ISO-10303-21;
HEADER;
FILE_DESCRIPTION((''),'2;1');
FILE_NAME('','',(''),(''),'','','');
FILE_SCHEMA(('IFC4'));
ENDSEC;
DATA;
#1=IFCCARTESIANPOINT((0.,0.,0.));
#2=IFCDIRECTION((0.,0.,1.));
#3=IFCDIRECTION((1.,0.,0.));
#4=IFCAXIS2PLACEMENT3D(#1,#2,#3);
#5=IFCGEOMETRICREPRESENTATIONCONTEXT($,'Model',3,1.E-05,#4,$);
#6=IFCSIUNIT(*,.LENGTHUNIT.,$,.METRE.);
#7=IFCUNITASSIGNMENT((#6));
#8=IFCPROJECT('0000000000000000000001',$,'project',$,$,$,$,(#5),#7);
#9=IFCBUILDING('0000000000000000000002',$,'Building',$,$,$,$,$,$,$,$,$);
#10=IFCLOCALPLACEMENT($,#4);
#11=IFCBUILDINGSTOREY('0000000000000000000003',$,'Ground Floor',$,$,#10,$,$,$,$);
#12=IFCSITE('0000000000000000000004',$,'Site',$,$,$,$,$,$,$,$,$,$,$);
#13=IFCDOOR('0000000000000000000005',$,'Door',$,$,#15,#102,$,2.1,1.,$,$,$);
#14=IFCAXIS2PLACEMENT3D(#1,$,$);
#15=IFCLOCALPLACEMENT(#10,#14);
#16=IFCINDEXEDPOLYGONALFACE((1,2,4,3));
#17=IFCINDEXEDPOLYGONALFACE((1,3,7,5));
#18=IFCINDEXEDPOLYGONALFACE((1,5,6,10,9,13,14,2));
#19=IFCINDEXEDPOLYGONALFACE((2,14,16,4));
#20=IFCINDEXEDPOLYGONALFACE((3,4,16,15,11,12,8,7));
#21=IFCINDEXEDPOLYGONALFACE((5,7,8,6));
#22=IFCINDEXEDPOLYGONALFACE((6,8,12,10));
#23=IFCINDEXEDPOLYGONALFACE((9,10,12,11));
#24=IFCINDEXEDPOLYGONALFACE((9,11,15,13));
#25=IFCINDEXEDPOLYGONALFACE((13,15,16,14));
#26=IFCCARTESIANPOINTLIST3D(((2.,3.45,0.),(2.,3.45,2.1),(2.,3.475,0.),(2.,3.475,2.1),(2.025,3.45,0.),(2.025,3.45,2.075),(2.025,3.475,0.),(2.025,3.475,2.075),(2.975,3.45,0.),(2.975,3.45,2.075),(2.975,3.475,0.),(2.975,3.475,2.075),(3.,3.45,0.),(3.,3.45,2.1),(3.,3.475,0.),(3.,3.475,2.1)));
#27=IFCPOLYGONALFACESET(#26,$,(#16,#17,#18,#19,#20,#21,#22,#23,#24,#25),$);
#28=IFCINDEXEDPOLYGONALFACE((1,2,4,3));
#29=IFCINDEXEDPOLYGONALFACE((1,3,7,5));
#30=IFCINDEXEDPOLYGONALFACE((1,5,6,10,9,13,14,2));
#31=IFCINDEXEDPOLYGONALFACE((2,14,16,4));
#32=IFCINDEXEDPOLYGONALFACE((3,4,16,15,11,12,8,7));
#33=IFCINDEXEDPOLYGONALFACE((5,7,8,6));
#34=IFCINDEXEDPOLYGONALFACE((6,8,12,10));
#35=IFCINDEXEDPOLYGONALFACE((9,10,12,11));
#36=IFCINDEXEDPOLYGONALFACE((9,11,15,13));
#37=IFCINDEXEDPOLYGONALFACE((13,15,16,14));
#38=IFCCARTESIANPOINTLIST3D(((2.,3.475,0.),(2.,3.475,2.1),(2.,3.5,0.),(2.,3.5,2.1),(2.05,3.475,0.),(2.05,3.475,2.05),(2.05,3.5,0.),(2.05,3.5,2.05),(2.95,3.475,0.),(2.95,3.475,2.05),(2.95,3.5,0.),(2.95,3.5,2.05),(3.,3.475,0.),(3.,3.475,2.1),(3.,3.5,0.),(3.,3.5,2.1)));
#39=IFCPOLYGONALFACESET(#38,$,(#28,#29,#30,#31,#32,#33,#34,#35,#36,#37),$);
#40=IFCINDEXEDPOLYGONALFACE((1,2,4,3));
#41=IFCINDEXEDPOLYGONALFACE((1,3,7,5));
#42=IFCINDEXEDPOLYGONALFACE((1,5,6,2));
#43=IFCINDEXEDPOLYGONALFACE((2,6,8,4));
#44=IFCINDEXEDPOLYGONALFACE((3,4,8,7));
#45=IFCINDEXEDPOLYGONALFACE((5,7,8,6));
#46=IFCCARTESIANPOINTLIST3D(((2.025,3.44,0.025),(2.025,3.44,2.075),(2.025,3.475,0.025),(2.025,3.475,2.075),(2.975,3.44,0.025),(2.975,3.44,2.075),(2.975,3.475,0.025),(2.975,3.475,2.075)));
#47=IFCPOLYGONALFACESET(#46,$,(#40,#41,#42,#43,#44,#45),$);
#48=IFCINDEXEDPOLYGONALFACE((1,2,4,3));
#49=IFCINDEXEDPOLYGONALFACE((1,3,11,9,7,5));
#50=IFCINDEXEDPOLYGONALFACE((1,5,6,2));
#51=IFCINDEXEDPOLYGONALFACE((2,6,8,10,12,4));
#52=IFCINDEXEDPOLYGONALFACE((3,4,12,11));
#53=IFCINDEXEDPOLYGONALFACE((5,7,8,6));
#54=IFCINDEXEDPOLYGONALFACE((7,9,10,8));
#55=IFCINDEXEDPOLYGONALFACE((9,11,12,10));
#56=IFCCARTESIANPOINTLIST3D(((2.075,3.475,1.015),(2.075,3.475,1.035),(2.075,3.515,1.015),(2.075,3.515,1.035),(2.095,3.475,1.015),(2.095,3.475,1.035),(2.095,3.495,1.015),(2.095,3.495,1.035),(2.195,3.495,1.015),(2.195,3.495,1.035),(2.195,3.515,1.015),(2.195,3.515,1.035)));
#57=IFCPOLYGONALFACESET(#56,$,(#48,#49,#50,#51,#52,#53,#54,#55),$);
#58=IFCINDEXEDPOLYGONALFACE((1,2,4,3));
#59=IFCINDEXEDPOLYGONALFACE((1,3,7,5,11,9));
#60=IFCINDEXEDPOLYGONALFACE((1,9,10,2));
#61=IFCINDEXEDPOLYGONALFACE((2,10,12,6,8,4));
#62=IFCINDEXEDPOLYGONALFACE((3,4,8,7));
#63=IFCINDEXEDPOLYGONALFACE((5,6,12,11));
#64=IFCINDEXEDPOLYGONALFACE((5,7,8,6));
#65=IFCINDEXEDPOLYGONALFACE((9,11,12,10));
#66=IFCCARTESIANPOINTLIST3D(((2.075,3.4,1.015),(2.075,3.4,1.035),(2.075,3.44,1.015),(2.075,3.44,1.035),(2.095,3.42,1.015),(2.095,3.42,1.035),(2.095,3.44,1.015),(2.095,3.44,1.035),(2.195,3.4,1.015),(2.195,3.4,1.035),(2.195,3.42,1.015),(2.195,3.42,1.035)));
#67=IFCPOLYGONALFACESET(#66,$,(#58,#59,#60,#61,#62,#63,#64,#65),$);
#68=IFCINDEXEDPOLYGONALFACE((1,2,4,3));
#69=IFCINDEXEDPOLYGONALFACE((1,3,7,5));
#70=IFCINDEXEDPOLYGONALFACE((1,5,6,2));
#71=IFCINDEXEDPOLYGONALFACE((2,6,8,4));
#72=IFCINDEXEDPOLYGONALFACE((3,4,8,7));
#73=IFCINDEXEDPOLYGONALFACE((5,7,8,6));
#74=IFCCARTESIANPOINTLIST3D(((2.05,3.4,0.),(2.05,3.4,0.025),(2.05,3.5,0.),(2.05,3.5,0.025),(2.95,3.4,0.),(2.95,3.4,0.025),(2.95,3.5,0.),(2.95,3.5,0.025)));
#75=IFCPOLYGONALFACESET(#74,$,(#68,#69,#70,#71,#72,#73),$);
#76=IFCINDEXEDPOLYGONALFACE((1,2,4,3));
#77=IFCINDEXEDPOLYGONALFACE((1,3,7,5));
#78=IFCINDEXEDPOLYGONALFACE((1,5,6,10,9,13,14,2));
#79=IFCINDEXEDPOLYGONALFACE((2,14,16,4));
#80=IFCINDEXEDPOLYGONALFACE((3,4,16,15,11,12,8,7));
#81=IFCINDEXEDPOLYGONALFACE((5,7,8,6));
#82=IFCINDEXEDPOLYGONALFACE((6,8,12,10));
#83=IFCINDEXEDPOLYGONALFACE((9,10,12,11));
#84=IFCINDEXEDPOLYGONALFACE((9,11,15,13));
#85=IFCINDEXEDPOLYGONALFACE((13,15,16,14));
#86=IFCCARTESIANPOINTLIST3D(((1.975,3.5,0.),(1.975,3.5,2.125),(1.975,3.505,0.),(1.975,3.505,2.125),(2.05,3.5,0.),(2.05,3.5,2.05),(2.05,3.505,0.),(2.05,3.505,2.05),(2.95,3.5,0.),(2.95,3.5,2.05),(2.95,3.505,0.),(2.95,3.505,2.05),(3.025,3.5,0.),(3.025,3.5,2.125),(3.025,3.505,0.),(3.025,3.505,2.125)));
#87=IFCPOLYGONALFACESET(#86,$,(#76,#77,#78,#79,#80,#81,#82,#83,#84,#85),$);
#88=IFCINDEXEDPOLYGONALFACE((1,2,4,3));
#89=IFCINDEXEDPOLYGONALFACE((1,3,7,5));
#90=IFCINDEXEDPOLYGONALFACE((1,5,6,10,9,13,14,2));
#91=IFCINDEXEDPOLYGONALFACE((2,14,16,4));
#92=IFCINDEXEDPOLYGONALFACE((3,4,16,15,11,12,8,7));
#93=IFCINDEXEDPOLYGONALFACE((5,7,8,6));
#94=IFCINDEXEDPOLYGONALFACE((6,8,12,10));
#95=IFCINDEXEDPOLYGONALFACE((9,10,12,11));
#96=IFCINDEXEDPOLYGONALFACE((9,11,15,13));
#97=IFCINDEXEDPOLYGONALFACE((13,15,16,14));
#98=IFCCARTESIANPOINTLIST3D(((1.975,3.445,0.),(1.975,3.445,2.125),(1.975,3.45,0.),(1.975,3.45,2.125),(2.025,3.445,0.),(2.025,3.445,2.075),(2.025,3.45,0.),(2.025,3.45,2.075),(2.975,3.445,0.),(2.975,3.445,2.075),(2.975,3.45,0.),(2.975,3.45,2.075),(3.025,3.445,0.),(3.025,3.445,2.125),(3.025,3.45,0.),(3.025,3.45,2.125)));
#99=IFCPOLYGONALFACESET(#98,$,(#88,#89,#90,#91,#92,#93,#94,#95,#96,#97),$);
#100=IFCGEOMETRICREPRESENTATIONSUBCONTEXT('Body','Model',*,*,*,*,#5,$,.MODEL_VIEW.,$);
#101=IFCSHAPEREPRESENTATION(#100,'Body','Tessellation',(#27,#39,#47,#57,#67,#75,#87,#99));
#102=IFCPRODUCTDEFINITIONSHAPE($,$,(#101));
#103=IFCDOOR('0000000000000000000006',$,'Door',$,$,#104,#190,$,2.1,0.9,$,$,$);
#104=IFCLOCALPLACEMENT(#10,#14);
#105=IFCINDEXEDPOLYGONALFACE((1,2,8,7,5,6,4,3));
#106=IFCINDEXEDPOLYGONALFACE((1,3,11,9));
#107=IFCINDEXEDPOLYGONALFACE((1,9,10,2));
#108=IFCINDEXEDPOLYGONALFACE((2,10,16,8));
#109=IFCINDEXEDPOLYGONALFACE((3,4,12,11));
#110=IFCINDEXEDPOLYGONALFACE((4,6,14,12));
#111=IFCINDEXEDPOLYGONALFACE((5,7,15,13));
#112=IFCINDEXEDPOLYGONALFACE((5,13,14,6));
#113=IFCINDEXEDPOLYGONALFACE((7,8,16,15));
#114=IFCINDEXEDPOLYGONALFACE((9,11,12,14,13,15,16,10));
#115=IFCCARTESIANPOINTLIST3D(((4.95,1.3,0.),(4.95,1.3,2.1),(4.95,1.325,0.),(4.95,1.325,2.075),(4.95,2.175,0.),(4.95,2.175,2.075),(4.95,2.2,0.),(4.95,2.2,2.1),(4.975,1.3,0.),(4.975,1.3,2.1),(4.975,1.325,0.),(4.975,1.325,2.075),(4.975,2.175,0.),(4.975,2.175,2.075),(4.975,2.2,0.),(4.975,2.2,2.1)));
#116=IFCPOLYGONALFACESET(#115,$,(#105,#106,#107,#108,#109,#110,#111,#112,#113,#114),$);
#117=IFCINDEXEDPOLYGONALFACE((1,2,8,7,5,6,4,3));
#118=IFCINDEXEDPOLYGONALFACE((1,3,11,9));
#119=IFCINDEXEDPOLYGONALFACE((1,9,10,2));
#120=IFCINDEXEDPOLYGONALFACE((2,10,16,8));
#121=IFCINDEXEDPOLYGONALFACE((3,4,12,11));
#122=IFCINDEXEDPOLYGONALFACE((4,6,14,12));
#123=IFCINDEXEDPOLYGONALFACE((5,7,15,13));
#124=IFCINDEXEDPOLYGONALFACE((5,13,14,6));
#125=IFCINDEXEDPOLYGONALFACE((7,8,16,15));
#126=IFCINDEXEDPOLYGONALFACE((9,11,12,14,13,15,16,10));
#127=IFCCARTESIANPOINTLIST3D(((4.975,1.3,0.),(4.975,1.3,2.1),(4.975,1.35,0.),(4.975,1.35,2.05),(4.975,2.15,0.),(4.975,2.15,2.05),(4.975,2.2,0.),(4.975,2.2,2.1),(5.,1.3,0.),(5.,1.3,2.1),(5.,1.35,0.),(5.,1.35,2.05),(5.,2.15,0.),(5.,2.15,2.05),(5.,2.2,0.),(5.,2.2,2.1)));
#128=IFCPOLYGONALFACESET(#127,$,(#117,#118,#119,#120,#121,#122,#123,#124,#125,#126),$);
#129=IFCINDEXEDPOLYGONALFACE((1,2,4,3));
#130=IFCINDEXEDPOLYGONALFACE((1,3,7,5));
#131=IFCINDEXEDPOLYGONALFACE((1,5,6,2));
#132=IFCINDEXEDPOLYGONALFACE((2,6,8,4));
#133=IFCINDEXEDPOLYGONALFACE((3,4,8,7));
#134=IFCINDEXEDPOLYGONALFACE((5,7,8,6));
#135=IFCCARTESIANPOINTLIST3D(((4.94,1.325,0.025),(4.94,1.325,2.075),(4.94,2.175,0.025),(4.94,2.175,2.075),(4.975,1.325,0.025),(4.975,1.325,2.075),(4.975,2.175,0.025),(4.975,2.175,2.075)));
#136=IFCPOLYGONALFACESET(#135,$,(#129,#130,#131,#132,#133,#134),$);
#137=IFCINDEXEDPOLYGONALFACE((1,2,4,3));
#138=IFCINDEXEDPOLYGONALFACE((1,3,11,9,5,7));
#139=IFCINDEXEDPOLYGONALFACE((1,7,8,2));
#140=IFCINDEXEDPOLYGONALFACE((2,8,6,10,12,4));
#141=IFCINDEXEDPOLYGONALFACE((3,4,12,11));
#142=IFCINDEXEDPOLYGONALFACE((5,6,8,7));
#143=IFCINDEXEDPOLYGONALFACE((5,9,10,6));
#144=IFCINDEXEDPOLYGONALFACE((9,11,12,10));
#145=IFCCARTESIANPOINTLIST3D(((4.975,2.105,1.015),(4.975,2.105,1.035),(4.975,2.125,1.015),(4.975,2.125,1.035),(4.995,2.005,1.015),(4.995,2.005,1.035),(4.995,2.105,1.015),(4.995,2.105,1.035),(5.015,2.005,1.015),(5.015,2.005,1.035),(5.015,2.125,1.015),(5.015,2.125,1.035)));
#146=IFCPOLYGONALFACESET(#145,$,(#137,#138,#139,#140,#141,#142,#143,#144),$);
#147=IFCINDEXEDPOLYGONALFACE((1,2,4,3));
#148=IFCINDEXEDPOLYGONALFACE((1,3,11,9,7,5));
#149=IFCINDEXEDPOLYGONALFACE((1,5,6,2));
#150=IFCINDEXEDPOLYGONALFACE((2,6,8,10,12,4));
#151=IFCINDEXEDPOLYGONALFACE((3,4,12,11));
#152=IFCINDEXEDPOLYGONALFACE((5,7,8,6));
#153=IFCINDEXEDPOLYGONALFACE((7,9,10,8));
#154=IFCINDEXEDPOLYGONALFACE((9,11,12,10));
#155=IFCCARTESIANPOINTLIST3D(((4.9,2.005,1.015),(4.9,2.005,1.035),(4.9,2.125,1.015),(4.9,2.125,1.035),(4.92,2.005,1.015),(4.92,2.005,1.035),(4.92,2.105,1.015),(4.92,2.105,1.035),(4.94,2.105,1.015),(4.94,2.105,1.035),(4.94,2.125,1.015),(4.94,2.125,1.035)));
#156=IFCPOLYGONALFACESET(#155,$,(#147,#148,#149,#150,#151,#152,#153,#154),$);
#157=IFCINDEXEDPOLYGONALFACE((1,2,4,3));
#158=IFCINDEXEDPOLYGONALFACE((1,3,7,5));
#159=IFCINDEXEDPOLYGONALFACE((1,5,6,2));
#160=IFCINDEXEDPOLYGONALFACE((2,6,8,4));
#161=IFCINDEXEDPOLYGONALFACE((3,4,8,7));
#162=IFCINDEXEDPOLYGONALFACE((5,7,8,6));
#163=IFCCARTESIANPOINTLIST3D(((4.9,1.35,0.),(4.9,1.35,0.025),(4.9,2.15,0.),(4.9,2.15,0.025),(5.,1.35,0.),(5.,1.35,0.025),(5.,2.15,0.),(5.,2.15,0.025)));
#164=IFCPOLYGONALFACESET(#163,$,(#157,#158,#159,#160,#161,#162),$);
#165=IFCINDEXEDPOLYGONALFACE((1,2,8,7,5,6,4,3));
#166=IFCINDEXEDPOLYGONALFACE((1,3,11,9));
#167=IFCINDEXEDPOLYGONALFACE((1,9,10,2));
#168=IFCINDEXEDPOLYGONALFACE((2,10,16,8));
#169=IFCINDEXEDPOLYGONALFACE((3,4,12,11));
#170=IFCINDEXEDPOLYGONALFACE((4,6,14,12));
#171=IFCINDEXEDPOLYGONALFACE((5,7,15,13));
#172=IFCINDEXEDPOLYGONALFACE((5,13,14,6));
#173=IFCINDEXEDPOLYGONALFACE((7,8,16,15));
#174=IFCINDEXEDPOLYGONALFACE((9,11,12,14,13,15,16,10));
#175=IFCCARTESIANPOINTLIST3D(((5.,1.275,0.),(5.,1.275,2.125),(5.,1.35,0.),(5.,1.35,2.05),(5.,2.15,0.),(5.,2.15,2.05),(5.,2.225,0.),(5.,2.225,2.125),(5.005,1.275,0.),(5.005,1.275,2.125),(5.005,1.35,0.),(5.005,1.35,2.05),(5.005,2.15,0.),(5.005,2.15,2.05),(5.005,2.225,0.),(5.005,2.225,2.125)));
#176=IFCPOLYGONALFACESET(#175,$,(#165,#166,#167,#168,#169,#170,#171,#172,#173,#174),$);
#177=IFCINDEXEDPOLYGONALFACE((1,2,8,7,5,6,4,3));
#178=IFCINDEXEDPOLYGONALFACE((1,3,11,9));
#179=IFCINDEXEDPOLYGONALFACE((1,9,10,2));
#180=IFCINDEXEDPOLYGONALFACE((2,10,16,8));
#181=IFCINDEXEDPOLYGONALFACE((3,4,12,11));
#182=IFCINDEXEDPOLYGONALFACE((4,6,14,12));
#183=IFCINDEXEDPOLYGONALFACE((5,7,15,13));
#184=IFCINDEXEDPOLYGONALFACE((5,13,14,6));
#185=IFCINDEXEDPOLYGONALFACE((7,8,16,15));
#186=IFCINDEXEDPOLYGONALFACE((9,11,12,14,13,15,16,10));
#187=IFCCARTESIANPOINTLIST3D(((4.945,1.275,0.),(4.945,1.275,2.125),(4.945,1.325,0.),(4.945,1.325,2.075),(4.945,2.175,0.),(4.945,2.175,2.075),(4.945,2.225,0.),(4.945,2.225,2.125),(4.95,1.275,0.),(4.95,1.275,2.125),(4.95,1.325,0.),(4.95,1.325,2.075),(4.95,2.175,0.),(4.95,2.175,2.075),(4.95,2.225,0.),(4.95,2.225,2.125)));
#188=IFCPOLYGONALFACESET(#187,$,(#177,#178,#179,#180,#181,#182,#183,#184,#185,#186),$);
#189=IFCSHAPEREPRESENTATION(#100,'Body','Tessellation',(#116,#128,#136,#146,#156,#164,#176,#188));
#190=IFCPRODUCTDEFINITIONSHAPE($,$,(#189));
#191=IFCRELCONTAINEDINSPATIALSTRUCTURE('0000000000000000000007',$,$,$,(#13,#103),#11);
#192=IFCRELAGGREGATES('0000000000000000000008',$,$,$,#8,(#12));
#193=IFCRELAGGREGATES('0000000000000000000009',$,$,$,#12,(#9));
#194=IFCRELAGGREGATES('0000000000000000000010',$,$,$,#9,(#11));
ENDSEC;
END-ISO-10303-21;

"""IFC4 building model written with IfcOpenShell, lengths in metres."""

from ifc_helpers import new_model, si_unit, frame, origin_with_axes, place, context, subcontext, project, spatial, line, indexed_curve, outline, extrude, element, save


model = new_model("IFC4")

# Units and contexts
model_context = context("Model", 3, precision=1e-05, world=origin_with_axes())
body_context = subcontext(model_context, "Body", "Model", "MODEL_VIEW")
ifc_project = project(units=[si_unit("LENGTHUNIT", "METRE")], contexts=[model_context])

# Site, building, storey
site = spatial("IfcSite", under=ifc_project, Name="Site")
building = spatial("IfcBuilding", under=site, Name="Building")
storey_placement = place(None, origin_with_axes())
storey = spatial("IfcBuildingStorey", under=building, at=storey_placement, Name="Ground Floor")

# Doors
door_1_placement = place(storey_placement, frame((3.0, 3.5, 0.0), z_axis=(0.0, 0.0, 1.0), x_axis=(-1.0, 0.0, 0.0)))
element("IfcDoor", 1, at=door_1_placement, inside=storey, Name="Door", OverallHeight=2.1, OverallWidth=1.0, context=body_context, shape_type="SweptSolid", body=[
    extrude(outline(indexed_curve([(0.0, 0.0), (0.0, 2.1), (1.0, 2.1), (1.0, 0.0), (0.975, 0.0), (0.975, 2.075), (0.025, 2.075), (0.025, 0.0)], segments=[line(1, 2, 3, 4, 5, 6, 7, 8, 1)])), frame((0.0, 0.025, 0.0), z_axis=(0.0, -1.0, 0.0), x_axis=(1.0, 0.0, 0.0)), (0.0, 0.0, -1.0), 0.025),
    extrude(outline(indexed_curve([(0.0, 0.0), (0.0, 2.1), (1.0, 2.1), (1.0, 0.0), (0.95, 0.0), (0.95, 2.05), (0.05, 2.05), (0.05, 0.0)], segments=[line(1, 2, 3, 4, 5, 6, 7, 8, 1)])), frame((0.0, 0.0, 0.0), z_axis=(0.0, -1.0, 0.0), x_axis=(1.0, 0.0, 0.0)), (0.0, 0.0, -1.0), 0.025),
    extrude(outline(indexed_curve([(0.0, 0.0), (0.95, 0.0), (0.95, 0.035), (0.0, 0.035)], segments=[line(1, 2, 3, 4, 1)])), frame((0.025, 0.025, 0.025), z_axis=(0.0, 0.0, 1.0), x_axis=(1.0, 0.0, 0.0)), (0.0, 0.0, 1.0), 2.05),
    extrude(outline(indexed_curve([(0.0, 0.0), (0.0, -0.04), (-0.12, -0.04), (-0.12, -0.02), (-0.02, -0.02), (-0.02, 0.0)], segments=[line(1, 2, 3, 4, 5, 6, 1)])), frame((0.925, 0.025, 1.015), z_axis=(0.0, 0.0, 1.0), x_axis=(1.0, 0.0, 0.0)), (0.0, 0.0, 1.0), 0.02),
    extrude(outline(indexed_curve([(0.0, 0.0), (0.0, 0.04), (-0.12, 0.04), (-0.12, 0.02), (-0.02, 0.02), (-0.02, 0.0)], segments=[line(1, 2, 3, 4, 5, 6, 1)])), frame((0.925, 0.06, 1.015), z_axis=(0.0, 0.0, 1.0), x_axis=(1.0, 0.0, 0.0)), (0.0, 0.0, 1.0), 0.02),
    extrude(outline(indexed_curve([(0.0, 0.0), (0.9, 0.0), (0.9, 0.1), (0.0, 0.1)], segments=[line(1, 2, 3, 4, 1)])), frame((0.05, 0.0, 0.0), z_axis=(0.0, 0.0, 1.0), x_axis=(1.0, 0.0, 0.0)), (0.0, 0.0, 1.0), 0.025),
    extrude(outline(indexed_curve([(0.0, 0.0), (0.0, 2.125), (1.05, 2.125), (1.05, 0.0), (0.975, 0.0), (0.975, 2.05), (0.075, 2.05), (0.075, 0.0)], segments=[line(1, 2, 3, 4, 5, 6, 7, 8, 1)])), frame((-0.025, -0.005, 0.0), z_axis=(0.0, -1.0, 0.0), x_axis=(1.0, 0.0, 0.0)), (0.0, 0.0, -1.0), 0.005),
    extrude(outline(indexed_curve([(0.0, 0.0), (0.0, 2.125), (1.05, 2.125), (1.05, 0.0), (1.0, 0.0), (1.0, 2.075), (0.05, 2.075), (0.05, 0.0)], segments=[line(1, 2, 3, 4, 5, 6, 7, 8, 1)])), frame((-0.025, 0.05, 0.0), z_axis=(0.0, -1.0, 0.0), x_axis=(1.0, 0.0, 0.0)), (0.0, 0.0, -1.0), 0.005),
])
door_2_placement = place(storey_placement, frame((5.0, 1.3, 0.0), z_axis=(0.0, 0.0, 1.0), x_axis=(0.0, 1.0, 0.0)))
element("IfcDoor", 2, at=door_2_placement, inside=storey, Name="Door", OverallHeight=2.1, OverallWidth=0.9, context=body_context, shape_type="SweptSolid", body=[
    extrude(outline(indexed_curve([(0.0, 0.0), (0.0, 2.1), (0.9, 2.1), (0.9, 0.0), (0.875, 0.0), (0.875, 2.075), (0.025, 2.075), (0.025, 0.0)], segments=[line(1, 2, 3, 4, 5, 6, 7, 8, 1)])), frame((0.0, 0.025, 0.0), z_axis=(0.0, -1.0, 0.0), x_axis=(1.0, 0.0, 0.0)), (0.0, 0.0, -1.0), 0.025),
    extrude(outline(indexed_curve([(0.0, 0.0), (0.0, 2.1), (0.9, 2.1), (0.9, 0.0), (0.85, 0.0), (0.85, 2.05), (0.05, 2.05), (0.05, 0.0)], segments=[line(1, 2, 3, 4, 5, 6, 7, 8, 1)])), frame((0.0, 0.0, 0.0), z_axis=(0.0, -1.0, 0.0), x_axis=(1.0, 0.0, 0.0)), (0.0, 0.0, -1.0), 0.025),
    extrude(outline(indexed_curve([(0.0, 0.0), (0.85, 0.0), (0.85, 0.035), (0.0, 0.035)], segments=[line(1, 2, 3, 4, 1)])), frame((0.025, 0.025, 0.025), z_axis=(0.0, 0.0, 1.0), x_axis=(1.0, 0.0, 0.0)), (0.0, 0.0, 1.0), 2.05),
    extrude(outline(indexed_curve([(0.0, 0.0), (0.0, -0.04), (-0.12, -0.04), (-0.12, -0.02), (-0.02, -0.02), (-0.02, 0.0)], segments=[line(1, 2, 3, 4, 5, 6, 1)])), frame((0.825, 0.025, 1.015), z_axis=(0.0, 0.0, 1.0), x_axis=(1.0, 0.0, 0.0)), (0.0, 0.0, 1.0), 0.02),
    extrude(outline(indexed_curve([(0.0, 0.0), (0.0, 0.04), (-0.12, 0.04), (-0.12, 0.02), (-0.02, 0.02), (-0.02, 0.0)], segments=[line(1, 2, 3, 4, 5, 6, 1)])), frame((0.825, 0.06, 1.015), z_axis=(0.0, 0.0, 1.0), x_axis=(1.0, 0.0, 0.0)), (0.0, 0.0, 1.0), 0.02),
    extrude(outline(indexed_curve([(0.0, 0.0), (0.8, 0.0), (0.8, 0.1), (0.0, 0.1)], segments=[line(1, 2, 3, 4, 1)])), frame((0.05, 0.0, 0.0), z_axis=(0.0, 0.0, 1.0), x_axis=(1.0, 0.0, 0.0)), (0.0, 0.0, 1.0), 0.025),
    extrude(outline(indexed_curve([(0.0, 0.0), (0.0, 2.125), (0.95, 2.125), (0.95, 0.0), (0.875, 0.0), (0.875, 2.05), (0.075, 2.05), (0.075, 0.0)], segments=[line(1, 2, 3, 4, 5, 6, 7, 8, 1)])), frame((-0.025, -0.005, 0.0), z_axis=(0.0, -1.0, 0.0), x_axis=(1.0, 0.0, 0.0)), (0.0, 0.0, -1.0), 0.005),
    extrude(outline(indexed_curve([(0.0, 0.0), (0.0, 2.125), (0.95, 2.125), (0.95, 0.0), (0.9, 0.0), (0.9, 2.075), (0.05, 2.075), (0.05, 0.0)], segments=[line(1, 2, 3, 4, 5, 6, 7, 8, 1)])), frame((-0.025, 0.05, 0.0), z_axis=(0.0, -1.0, 0.0), x_axis=(1.0, 0.0, 0.0)), (0.0, 0.0, -1.0), 0.005),
])

save(model, "model.ifc")
